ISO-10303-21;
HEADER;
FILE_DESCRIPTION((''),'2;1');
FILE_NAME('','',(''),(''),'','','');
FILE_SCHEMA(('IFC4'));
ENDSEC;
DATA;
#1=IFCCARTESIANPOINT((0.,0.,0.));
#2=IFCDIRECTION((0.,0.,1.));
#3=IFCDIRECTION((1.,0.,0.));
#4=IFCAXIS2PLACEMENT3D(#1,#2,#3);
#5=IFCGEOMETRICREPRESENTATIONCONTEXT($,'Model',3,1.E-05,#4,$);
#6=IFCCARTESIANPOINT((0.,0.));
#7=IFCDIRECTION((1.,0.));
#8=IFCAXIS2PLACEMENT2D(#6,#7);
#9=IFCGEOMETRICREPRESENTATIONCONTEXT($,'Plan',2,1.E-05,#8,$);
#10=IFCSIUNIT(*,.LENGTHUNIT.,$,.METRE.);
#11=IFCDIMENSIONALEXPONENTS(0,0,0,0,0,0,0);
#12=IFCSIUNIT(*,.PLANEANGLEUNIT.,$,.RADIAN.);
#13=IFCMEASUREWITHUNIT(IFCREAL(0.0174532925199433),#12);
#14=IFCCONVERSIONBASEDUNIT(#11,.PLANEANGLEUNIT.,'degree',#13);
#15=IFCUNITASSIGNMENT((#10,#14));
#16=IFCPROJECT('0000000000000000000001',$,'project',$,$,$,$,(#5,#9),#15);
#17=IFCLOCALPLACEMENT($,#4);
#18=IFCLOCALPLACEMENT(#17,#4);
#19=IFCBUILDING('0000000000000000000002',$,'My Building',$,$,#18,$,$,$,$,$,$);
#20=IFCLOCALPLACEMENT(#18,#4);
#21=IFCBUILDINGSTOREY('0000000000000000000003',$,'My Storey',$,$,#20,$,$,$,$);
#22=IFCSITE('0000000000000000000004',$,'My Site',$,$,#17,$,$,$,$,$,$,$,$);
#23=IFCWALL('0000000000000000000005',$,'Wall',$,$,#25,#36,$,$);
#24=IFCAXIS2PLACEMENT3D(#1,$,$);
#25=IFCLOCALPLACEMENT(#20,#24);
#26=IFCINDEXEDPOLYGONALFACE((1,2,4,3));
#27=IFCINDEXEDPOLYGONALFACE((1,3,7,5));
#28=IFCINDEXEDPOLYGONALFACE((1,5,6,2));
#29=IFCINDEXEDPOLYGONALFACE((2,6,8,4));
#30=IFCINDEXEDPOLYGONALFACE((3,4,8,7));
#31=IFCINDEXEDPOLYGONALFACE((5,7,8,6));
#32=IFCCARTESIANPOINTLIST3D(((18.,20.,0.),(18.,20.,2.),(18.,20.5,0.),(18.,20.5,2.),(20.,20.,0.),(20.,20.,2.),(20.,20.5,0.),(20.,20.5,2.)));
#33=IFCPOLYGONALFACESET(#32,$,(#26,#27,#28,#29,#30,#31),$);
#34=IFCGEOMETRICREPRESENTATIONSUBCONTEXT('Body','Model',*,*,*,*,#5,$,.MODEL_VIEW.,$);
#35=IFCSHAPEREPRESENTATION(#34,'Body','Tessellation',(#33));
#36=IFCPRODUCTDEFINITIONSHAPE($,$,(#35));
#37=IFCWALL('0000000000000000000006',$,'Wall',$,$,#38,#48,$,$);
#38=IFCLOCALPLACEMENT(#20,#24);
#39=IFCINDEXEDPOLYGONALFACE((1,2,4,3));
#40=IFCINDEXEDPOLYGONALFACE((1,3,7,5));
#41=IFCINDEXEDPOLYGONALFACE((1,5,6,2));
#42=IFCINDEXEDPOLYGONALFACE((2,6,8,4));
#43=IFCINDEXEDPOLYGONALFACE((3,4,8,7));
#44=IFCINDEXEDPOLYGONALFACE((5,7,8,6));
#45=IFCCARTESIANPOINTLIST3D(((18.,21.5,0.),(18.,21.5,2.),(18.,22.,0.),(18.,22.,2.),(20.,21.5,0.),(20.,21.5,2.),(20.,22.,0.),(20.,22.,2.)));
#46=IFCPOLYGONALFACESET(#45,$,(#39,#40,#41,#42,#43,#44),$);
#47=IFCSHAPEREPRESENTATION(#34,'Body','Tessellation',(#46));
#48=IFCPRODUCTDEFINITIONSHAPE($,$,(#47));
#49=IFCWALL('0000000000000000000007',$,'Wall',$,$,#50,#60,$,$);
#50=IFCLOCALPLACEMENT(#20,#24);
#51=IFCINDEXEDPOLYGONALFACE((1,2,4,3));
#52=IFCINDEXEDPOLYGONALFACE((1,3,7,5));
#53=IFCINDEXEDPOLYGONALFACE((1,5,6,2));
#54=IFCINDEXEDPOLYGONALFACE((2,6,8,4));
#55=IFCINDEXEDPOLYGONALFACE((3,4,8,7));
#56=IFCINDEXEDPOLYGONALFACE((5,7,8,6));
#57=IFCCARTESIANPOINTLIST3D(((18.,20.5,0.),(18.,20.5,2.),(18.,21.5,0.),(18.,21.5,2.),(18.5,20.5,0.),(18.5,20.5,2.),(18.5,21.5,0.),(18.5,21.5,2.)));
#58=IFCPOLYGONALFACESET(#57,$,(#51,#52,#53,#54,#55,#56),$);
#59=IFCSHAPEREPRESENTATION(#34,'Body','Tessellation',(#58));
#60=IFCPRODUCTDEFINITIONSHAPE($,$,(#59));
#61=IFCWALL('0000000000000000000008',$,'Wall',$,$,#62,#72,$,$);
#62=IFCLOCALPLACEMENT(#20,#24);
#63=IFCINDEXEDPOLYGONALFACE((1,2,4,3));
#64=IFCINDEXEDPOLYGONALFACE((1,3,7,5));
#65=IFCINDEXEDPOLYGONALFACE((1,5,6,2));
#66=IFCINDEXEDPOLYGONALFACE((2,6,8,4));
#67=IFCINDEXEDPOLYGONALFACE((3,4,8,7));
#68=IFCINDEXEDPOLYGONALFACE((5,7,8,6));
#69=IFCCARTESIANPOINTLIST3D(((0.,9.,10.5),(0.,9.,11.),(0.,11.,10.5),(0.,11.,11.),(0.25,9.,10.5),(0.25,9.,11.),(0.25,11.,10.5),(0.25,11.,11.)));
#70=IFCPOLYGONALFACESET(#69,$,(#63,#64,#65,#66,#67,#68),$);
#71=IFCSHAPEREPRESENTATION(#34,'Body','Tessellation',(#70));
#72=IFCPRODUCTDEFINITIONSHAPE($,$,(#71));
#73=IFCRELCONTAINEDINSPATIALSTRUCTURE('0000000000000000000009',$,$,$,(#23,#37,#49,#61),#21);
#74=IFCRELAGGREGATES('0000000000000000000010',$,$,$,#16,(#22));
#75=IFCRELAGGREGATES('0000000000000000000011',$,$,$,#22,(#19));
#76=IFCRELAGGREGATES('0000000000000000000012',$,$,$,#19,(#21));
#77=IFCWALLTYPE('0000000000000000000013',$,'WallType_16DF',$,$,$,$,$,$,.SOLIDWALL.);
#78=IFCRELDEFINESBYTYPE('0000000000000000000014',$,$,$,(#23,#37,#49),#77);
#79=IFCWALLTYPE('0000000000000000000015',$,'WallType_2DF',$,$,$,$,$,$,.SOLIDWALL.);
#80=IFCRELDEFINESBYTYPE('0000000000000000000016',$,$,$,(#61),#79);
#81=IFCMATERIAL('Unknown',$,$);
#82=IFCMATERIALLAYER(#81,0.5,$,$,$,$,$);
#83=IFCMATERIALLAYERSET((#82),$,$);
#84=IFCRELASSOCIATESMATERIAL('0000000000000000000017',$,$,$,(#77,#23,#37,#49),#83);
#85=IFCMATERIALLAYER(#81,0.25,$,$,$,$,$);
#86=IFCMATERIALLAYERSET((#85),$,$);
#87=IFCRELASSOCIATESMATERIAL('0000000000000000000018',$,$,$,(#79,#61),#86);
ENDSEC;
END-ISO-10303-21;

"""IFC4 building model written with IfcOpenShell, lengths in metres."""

from ifc_helpers import new_model, entity, si_unit, converted_unit, frame, origin_with_axes, origin_2d_with_axis, place, context, subcontext, project, spatial, indexed_curve, outline, extrude, material, layer, layer_set, layer_usage, type_object, element, save


model = new_model("IFC4")

# Units and contexts
model_context = context("Model", 3, precision=1e-05, world=origin_with_axes())
plan_context = context("Plan", 2, precision=1e-05, world=origin_2d_with_axis())
body_context_1 = subcontext(model_context, "Body", "Model", "MODEL_VIEW")
ifc_project = project(units=[si_unit("LENGTHUNIT", "METRE"), converted_unit("PLANEANGLEUNIT", "degree", entity("IfcReal", 0.0174532925199433), si_unit("PLANEANGLEUNIT", "RADIAN"), dimensions=[0, 0, 0, 0, 0, 0, 0])], contexts=[model_context, plan_context])

# Site, building, storey
site_placement = place(None, origin_with_axes())
site = spatial("IfcSite", under=ifc_project, at=site_placement, Name="My Site")
building_placement = place(site_placement, origin_with_axes())
building = spatial("IfcBuilding", under=site, at=building_placement, Name="My Building")
storey_placement = place(building_placement, origin_with_axes())
storey = spatial("IfcBuildingStorey", under=building, at=storey_placement, Name="My Storey")

# Walls
ifc_material = material(Name="Unknown")
ifc_layer_1 = layer(ifc_material, 0.5)
ifc_layer_set_1 = layer_set([ifc_layer_1])
ifc_layer_usage_1 = layer_usage(ifc_layer_set_1, "AXIS2", "POSITIVE", 0.0)
wall_type_1 = type_object("IfcWallType", Name="WallType_16DF", PredefinedType="SOLIDWALL", material=ifc_layer_set_1)
wall_1_placement = place(storey_placement, frame((18.0, 20.0, 0.0), z_axis=(0.0, 0.0, 1.0), x_axis=(1.0, 0.0, 0.0)))
element("IfcWall", 1, at=wall_1_placement, inside=storey, type_object=wall_type_1, material=ifc_layer_usage_1, Name="Wall", context=body_context_1, shape_type="SweptSolid", body=[
    extrude(outline(indexed_curve([(0.0, 0.0), (0.0, 0.5), (2.0, 0.5), (2.0, 0.0), (0.0, 0.0)], self_intersect=False)), origin_with_axes(), (0.0, 0.0, 1.0), 2.0),
])
ifc_layer_usage_2 = layer_usage(ifc_layer_set_1, "AXIS2", "POSITIVE", 0.0)
wall_2_placement = place(storey_placement, frame((18.0, 21.5, 0.0), z_axis=(0.0, 0.0, 1.0), x_axis=(1.0, 0.0, 0.0)))
element("IfcWall", 2, at=wall_2_placement, inside=storey, type_object=wall_type_1, material=ifc_layer_usage_2, Name="Wall", context=body_context_1, shape_type="SweptSolid", body=[
    extrude(outline(indexed_curve([(0.0, 0.0), (0.0, 0.5), (2.0, 0.5), (2.0, 0.0), (0.0, 0.0)], self_intersect=False)), origin_with_axes(), (0.0, 0.0, 1.0), 2.0),
])
ifc_layer_usage_3 = layer_usage(ifc_layer_set_1, "AXIS2", "POSITIVE", 0.0)
wall_3_placement = place(storey_placement, frame((18.0, 21.5, 0.0), z_axis=(0.0, 0.0, 1.0), x_axis=(0.0, -1.0, 0.0)))
element("IfcWall", 3, at=wall_3_placement, inside=storey, type_object=wall_type_1, material=ifc_layer_usage_3, Name="Wall", context=body_context_1, shape_type="SweptSolid", body=[
    extrude(outline(indexed_curve([(0.0, 0.0), (0.0, 0.5), (1.0, 0.5), (1.0, 0.0), (0.0, 0.0)], self_intersect=False)), origin_with_axes(), (0.0, 0.0, 1.0), 2.0),
])

# Shared definitions
ifc_layer_2 = layer(ifc_material, 0.25)
ifc_layer_set_2 = layer_set([ifc_layer_2])
wall_type_2 = type_object("IfcWallType", Name="WallType_2DF", PredefinedType="SOLIDWALL", material=ifc_layer_set_2)

# Wall
ifc_layer_usage_4 = layer_usage(ifc_layer_set_2, "AXIS2", "POSITIVE", 0.0)
wall_4_placement = place(storey_placement, frame((0.25, 9.0, 10.5), z_axis=(0.0, 0.0, 1.0), x_axis=(0.0, 1.0, 0.0)))
element("IfcWall", 4, at=wall_4_placement, inside=storey, type_object=wall_type_2, material=ifc_layer_usage_4, Name="Wall", context=body_context_1, shape_type="SweptSolid", body=[
    extrude(outline(indexed_curve([(0.0, 0.0), (0.0, 0.25), (2.0, 0.25), (2.0, 0.0), (0.0, 0.0)], self_intersect=False)), origin_with_axes(), (0.0, 0.0, 1.0), 0.5),
])

save(model, "model.ifc")
